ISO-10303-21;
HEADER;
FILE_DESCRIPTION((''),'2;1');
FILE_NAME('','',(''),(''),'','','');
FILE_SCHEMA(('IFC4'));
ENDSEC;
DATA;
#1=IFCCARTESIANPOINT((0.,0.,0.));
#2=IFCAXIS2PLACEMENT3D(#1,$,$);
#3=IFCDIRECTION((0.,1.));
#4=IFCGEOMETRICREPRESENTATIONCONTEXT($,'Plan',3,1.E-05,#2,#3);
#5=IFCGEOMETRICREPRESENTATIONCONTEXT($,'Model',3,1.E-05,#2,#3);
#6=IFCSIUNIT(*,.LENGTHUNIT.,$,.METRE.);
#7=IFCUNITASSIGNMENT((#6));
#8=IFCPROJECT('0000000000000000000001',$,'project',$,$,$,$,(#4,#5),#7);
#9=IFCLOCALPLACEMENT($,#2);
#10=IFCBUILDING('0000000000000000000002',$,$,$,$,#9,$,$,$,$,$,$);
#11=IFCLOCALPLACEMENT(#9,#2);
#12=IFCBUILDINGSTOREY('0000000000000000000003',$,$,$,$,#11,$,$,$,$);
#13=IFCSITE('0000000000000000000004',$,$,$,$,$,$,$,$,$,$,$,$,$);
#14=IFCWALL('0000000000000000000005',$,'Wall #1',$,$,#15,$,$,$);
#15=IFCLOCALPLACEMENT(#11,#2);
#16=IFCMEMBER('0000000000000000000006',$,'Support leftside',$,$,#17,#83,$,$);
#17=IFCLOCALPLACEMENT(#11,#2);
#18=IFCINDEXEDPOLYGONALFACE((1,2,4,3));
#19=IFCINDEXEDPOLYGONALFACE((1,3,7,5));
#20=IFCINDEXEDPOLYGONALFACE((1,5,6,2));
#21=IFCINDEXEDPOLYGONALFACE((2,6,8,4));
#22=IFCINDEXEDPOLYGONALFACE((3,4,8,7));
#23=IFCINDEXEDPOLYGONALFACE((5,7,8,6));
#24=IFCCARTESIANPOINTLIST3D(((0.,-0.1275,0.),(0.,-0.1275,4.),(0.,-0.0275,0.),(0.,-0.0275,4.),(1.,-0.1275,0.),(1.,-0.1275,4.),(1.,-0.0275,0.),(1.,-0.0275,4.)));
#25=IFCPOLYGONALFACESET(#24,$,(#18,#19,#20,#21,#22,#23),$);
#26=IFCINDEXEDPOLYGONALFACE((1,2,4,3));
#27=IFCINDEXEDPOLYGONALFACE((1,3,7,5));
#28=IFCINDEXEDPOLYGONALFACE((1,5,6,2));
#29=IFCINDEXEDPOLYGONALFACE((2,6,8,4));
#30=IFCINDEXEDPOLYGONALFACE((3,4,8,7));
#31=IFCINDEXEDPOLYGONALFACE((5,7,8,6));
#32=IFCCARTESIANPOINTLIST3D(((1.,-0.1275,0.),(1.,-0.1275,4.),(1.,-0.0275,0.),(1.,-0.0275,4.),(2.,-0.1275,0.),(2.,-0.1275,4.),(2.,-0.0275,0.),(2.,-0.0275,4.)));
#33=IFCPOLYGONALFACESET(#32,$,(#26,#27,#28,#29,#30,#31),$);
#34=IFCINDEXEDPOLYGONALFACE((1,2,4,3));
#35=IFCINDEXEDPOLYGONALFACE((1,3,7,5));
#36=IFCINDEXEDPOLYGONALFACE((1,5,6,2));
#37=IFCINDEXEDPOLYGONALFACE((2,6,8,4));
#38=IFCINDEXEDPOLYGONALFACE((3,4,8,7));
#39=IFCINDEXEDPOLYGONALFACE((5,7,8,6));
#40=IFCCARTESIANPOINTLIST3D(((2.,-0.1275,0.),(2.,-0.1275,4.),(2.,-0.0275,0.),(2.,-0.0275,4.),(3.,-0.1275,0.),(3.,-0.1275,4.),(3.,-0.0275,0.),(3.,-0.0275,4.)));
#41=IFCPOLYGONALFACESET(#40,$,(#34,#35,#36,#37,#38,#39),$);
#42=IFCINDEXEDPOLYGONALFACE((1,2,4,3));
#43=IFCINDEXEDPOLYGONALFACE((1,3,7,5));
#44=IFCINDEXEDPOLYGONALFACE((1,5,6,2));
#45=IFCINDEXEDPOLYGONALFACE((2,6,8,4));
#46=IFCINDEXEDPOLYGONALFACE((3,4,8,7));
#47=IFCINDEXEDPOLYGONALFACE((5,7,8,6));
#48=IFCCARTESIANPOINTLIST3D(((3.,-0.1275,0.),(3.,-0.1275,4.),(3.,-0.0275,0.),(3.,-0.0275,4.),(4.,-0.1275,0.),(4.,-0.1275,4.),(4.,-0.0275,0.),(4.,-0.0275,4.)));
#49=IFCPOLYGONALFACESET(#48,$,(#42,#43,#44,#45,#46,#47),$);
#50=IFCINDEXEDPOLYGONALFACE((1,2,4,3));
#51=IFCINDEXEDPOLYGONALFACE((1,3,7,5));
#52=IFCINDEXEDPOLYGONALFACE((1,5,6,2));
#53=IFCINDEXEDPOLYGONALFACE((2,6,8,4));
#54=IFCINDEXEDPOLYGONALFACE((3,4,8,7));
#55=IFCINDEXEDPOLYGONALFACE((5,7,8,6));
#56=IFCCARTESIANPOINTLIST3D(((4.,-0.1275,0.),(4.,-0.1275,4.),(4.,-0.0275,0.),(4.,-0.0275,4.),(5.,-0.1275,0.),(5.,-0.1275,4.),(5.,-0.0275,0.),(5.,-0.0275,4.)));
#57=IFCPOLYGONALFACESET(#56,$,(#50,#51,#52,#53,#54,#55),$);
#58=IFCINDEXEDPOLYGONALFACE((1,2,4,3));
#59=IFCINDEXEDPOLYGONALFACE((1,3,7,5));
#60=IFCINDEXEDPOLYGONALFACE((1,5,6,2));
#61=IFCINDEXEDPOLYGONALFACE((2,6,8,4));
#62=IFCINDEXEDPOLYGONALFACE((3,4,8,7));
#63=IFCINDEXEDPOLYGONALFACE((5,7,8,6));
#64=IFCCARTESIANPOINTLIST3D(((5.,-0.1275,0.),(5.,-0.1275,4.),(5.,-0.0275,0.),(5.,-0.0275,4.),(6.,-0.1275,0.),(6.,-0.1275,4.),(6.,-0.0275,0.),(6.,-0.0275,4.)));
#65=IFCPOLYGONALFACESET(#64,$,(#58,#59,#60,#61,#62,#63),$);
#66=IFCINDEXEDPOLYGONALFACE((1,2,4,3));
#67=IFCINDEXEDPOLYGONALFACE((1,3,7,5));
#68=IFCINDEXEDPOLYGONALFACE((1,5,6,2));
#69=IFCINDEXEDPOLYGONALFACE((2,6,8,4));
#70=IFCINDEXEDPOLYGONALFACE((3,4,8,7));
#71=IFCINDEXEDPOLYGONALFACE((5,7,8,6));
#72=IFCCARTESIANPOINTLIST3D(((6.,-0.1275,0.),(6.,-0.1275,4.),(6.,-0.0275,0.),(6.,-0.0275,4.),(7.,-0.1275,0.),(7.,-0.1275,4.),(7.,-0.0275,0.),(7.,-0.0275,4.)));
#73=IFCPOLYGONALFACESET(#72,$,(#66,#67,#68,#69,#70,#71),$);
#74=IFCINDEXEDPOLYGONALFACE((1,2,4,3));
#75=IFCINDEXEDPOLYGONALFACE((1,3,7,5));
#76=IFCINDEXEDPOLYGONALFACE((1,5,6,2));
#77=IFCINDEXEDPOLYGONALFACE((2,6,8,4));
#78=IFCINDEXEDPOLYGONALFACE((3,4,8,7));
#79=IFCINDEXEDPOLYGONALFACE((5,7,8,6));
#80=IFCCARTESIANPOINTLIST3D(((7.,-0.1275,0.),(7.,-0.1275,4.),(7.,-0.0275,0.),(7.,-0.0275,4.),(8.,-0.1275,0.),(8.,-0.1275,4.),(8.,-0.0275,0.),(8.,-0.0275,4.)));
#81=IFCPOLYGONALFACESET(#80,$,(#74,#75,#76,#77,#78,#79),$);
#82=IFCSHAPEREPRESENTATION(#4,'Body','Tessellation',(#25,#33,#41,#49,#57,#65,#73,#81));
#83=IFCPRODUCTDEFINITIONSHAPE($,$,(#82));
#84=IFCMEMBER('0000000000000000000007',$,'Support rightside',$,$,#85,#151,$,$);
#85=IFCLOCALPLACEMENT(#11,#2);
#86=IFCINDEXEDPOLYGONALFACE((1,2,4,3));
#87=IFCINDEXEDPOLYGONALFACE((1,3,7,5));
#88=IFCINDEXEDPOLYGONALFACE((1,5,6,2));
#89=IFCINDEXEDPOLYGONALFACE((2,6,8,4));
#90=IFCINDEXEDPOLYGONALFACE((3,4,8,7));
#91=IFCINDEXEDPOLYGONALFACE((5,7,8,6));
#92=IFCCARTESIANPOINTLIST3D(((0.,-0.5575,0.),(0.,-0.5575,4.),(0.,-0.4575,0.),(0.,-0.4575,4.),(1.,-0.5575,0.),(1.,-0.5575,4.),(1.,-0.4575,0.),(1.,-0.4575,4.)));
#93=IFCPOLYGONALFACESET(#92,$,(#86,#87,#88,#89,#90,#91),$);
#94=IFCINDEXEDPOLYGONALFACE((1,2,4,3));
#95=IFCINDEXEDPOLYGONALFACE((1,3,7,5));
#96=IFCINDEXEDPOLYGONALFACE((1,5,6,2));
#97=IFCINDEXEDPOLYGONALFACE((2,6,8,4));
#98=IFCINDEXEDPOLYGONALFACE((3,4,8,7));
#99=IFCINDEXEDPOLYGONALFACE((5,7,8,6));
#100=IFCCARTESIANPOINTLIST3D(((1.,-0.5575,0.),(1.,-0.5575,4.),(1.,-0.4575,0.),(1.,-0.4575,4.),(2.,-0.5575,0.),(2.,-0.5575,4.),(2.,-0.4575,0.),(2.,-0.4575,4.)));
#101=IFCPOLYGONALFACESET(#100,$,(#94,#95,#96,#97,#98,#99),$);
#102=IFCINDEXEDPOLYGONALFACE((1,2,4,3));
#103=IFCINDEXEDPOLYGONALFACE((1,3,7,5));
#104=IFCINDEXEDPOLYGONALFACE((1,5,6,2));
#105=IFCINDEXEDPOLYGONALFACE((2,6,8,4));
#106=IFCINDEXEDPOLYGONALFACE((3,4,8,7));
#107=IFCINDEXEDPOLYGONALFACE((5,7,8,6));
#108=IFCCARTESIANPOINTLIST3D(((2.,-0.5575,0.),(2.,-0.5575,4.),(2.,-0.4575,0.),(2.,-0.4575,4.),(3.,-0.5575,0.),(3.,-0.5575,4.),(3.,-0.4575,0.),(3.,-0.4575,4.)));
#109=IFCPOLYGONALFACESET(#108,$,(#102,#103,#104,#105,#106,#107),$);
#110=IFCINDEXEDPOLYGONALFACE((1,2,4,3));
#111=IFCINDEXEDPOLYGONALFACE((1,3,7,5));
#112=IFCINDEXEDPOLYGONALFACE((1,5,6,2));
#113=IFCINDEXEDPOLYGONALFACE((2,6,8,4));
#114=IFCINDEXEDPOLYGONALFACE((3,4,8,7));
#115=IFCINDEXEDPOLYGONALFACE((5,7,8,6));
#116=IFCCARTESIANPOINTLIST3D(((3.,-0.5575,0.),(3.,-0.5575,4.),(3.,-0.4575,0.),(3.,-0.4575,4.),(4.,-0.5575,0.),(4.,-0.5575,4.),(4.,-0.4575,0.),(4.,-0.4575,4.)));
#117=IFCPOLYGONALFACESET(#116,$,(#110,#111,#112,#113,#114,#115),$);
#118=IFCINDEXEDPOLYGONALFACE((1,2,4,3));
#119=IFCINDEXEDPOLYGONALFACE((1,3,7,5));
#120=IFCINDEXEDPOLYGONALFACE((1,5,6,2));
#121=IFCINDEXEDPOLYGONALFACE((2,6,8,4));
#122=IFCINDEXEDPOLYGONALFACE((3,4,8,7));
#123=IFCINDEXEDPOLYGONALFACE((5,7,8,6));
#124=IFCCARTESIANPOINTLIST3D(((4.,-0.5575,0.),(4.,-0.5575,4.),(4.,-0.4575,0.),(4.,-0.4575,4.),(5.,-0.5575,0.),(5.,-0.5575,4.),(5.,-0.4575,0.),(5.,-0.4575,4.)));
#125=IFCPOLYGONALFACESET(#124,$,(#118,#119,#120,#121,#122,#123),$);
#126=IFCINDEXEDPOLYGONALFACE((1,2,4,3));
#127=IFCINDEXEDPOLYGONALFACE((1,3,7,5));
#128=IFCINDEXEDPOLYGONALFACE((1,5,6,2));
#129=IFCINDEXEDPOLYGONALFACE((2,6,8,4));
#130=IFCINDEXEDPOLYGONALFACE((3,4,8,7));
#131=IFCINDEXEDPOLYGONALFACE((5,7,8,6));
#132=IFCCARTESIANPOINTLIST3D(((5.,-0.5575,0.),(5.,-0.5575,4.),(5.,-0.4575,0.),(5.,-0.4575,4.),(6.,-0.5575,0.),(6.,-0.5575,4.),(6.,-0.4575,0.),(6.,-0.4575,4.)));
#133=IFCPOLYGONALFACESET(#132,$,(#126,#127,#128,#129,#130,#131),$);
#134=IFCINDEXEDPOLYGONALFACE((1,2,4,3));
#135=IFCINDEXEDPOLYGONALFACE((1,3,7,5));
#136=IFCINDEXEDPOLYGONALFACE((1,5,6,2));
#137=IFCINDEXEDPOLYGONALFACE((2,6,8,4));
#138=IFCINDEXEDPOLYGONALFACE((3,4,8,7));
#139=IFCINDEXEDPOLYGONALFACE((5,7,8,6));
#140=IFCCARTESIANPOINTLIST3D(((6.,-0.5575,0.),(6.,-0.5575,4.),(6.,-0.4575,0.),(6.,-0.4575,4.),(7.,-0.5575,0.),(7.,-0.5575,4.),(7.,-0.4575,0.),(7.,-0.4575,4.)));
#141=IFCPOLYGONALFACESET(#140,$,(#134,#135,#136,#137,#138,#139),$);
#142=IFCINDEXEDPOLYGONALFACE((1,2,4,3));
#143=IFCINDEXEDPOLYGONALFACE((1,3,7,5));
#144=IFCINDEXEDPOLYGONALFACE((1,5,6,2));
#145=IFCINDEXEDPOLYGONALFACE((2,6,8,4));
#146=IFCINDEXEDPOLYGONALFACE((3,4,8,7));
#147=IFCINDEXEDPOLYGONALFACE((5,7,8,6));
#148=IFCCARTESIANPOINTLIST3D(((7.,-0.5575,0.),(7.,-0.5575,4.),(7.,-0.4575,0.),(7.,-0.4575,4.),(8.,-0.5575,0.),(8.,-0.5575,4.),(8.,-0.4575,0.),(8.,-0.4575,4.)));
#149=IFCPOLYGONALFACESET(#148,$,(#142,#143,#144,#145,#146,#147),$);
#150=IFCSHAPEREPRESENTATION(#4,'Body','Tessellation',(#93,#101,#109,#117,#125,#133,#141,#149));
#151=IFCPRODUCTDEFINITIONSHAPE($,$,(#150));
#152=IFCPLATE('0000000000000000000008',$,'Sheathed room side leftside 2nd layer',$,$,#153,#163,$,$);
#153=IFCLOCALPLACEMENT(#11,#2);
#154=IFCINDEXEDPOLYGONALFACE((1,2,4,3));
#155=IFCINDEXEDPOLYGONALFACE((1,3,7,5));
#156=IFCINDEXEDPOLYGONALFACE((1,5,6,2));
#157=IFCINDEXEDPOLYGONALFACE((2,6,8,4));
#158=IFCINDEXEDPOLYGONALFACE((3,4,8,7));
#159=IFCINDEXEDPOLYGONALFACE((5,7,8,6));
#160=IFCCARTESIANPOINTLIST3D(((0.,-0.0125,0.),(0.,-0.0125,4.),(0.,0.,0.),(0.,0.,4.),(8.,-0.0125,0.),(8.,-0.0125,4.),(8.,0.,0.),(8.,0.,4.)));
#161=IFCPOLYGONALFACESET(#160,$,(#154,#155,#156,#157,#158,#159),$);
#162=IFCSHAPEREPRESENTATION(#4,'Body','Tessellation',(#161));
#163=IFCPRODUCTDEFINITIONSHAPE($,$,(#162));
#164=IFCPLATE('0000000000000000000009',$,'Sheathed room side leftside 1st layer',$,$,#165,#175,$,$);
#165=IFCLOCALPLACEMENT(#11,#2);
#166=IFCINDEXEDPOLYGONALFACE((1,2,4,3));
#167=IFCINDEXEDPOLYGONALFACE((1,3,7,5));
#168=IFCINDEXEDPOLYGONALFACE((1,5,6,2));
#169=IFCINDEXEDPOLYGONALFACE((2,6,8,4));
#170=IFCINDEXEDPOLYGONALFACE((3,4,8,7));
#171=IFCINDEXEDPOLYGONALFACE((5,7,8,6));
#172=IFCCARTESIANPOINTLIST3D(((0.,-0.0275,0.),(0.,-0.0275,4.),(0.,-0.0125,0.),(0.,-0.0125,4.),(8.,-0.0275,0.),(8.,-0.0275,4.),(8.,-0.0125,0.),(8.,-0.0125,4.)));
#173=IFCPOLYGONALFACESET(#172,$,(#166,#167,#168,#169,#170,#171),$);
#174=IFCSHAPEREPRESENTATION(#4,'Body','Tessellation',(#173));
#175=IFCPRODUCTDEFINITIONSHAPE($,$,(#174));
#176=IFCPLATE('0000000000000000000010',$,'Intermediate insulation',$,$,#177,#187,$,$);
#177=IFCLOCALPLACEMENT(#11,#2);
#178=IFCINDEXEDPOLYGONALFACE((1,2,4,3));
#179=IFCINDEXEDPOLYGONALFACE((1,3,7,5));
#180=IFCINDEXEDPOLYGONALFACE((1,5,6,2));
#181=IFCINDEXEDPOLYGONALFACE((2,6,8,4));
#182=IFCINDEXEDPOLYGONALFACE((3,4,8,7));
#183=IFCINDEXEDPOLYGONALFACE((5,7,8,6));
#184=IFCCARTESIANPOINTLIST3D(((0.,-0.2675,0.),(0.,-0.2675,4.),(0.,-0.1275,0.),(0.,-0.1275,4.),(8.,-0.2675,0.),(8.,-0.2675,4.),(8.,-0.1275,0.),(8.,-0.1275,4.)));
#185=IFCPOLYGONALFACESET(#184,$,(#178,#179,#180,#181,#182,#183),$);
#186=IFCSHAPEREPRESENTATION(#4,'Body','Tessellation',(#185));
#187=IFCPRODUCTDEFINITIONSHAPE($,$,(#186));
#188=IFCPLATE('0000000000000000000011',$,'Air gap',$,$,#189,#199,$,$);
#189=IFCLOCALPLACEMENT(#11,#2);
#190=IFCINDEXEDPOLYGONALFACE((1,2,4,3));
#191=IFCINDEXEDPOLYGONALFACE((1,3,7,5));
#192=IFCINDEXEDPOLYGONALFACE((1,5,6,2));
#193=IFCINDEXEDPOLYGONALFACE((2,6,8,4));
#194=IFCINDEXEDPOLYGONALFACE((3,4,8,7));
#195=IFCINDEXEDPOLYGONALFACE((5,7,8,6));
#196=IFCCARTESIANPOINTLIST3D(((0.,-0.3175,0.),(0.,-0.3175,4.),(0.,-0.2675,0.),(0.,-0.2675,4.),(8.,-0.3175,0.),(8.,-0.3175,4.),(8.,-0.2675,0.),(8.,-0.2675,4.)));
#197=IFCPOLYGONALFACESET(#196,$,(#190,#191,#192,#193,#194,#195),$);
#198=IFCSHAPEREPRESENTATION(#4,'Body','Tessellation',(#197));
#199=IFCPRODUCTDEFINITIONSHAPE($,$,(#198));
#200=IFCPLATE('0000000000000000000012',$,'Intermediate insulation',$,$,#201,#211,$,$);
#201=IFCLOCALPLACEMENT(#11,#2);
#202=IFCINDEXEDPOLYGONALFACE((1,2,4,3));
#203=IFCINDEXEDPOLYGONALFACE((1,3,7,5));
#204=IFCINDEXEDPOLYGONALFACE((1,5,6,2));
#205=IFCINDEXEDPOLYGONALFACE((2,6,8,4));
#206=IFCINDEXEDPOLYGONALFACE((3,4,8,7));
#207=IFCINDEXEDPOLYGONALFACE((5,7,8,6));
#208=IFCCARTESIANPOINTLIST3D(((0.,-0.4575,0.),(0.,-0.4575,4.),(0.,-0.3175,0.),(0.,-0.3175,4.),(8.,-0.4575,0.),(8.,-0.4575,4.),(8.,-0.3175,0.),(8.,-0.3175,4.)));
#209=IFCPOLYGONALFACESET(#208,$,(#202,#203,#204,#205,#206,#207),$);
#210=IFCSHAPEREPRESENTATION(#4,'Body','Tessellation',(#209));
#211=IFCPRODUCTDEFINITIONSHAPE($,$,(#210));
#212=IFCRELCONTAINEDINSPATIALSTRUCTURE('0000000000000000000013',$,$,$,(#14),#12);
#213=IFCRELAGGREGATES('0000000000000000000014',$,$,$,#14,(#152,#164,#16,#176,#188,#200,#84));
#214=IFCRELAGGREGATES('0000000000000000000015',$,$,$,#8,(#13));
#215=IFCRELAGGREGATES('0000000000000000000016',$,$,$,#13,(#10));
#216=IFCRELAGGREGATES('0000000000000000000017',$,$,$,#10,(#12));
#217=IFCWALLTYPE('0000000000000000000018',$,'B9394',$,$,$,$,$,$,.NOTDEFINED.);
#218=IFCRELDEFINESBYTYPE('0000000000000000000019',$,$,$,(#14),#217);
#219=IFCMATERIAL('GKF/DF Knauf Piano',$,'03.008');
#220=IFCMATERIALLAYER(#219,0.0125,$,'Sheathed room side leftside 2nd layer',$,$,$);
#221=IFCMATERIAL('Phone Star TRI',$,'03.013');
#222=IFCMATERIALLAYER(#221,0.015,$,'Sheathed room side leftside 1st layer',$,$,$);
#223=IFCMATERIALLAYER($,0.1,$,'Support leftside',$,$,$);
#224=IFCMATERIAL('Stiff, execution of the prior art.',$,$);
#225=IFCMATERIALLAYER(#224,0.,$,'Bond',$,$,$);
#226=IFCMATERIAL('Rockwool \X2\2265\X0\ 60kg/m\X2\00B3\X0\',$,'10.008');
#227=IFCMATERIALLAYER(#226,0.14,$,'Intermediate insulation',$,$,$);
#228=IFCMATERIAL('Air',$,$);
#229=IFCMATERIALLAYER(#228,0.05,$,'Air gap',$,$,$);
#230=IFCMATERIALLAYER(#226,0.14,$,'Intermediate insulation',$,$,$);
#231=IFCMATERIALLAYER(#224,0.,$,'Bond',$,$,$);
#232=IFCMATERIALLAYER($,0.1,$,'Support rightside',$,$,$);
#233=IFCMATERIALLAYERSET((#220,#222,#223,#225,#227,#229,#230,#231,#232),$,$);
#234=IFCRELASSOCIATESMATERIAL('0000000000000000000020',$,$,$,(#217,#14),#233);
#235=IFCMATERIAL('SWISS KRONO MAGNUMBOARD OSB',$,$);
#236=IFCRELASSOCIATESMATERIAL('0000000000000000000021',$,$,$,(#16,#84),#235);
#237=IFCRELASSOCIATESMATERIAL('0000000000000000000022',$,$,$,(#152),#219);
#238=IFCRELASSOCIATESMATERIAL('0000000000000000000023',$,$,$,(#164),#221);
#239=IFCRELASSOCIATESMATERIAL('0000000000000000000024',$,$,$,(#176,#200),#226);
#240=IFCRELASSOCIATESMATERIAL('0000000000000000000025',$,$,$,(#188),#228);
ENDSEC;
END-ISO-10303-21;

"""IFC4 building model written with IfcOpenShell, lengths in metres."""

from ifc_helpers import new_model, si_unit, direction, frame, frame_2d, origin, origin_with_axes, place, context, project, spatial, rectangle, extrude, material, layer, layer_set, type_object, element, aggregate, save


model = new_model("IFC4")

# Units and contexts
plan_context = context("Plan", 3, precision=1e-05, world=origin(), true_north=direction((0.0, 1.0)))
model_context = context("Model", 3, precision=1e-05, world=origin(), true_north=direction((0.0, 1.0)))
ifc_project = project(units=[si_unit("LENGTHUNIT", "METRE")], contexts=[plan_context, model_context])

# Site, building, storey
site = spatial("IfcSite", under=ifc_project)
building_placement = place(None, origin())
building = spatial("IfcBuilding", under=site, at=building_placement)
storey_placement = place(building_placement, origin())
storey = spatial("IfcBuildingStorey", under=building, at=storey_placement)

# Wall, members, plates
ifc_material_1 = material(Name="GKF/DF Knauf Piano", Category="03.008")
ifc_layer_1 = layer(ifc_material_1, 0.0125, Name="Sheathed room side leftside 2nd layer")
ifc_material_2 = material(Name="Phone Star TRI", Category="03.013")
ifc_layer_2 = layer(ifc_material_2, 0.015, Name="Sheathed room side leftside 1st layer")
ifc_layer_3 = layer(None, 0.1, Name="Support leftside")
ifc_material_3 = material(Name="Stiff, execution of the prior art.")
ifc_layer_4 = layer(ifc_material_3, 0.0, Name="Bond")
ifc_material_4 = material(Name="Rockwool ≥ 60kg/m³", Category="10.008")
ifc_layer_5 = layer(ifc_material_4, 0.14, Name="Intermediate insulation")
ifc_material_5 = material(Name="Air")
ifc_layer_6 = layer(ifc_material_5, 0.05, Name="Air gap")
ifc_layer_7 = layer(ifc_material_4, 0.14, Name="Intermediate insulation")
ifc_layer_8 = layer(ifc_material_3, 0.0, Name="Bond")
ifc_layer_9 = layer(None, 0.1, Name="Support rightside")
ifc_layer_set = layer_set([ifc_layer_1, ifc_layer_2, ifc_layer_3, ifc_layer_4, ifc_layer_5, ifc_layer_6, ifc_layer_7, ifc_layer_8, ifc_layer_9])
wall_type = type_object("IfcWallType", Name="B9394", PredefinedType="NOTDEFINED", material=ifc_layer_set)
wall_placement = place(None, frame((0.0, 0.0, 0.0), z_axis=(0.0, -1.0, 0.0), x_axis=(1.0, 0.0, 0.0)))
wall = element("IfcWall", 1, at=wall_placement, inside=storey, type_object=wall_type, material=ifc_layer_set, Name="Wall #1")
ifc_material_6 = material(Name="SWISS KRONO MAGNUMBOARD OSB")
member_1_placement = place(wall_placement, origin())
member_1 = element("IfcMember", 2, at=member_1_placement, material=ifc_material_6, Name="Support leftside", context=plan_context, shape_type="SweptSolid", body=[
    extrude(rectangle(XDim=1.0, YDim=0.1, at=frame_2d((0.5, 0.05), x_axis=(1.0, 0.0))), frame((0.0, 4.0, 0.0275), z_axis=(0.0, -1.0, 0.0), x_axis=(1.0, 0.0, 0.0)), (0.0, 0.0, 1.0), 4.0),
    extrude(rectangle(XDim=1.0, YDim=0.1, at=frame_2d((0.5, 0.05), x_axis=(1.0, 0.0))), frame((1.0, 4.0, 0.0275), z_axis=(0.0, -1.0, 0.0), x_axis=(1.0, 0.0, 0.0)), (0.0, 0.0, 1.0), 4.0),
    extrude(rectangle(XDim=1.0, YDim=0.1, at=frame_2d((0.5, 0.05), x_axis=(1.0, 0.0))), frame((2.0, 4.0, 0.0275), z_axis=(0.0, -1.0, 0.0), x_axis=(1.0, 0.0, 0.0)), (0.0, 0.0, 1.0), 4.0),
    extrude(rectangle(XDim=1.0, YDim=0.1, at=frame_2d((0.5, 0.05), x_axis=(1.0, 0.0))), frame((3.0, 4.0, 0.0275), z_axis=(0.0, -1.0, 0.0), x_axis=(1.0, 0.0, 0.0)), (0.0, 0.0, 1.0), 4.0),
    extrude(rectangle(XDim=1.0, YDim=0.1, at=frame_2d((0.5, 0.05), x_axis=(1.0, 0.0))), frame((4.0, 4.0, 0.0275), z_axis=(0.0, -1.0, 0.0), x_axis=(1.0, 0.0, 0.0)), (0.0, 0.0, 1.0), 4.0),
    extrude(rectangle(XDim=1.0, YDim=0.1, at=frame_2d((0.5, 0.05), x_axis=(1.0, 0.0))), frame((5.0, 4.0, 0.0275), z_axis=(0.0, -1.0, 0.0), x_axis=(1.0, 0.0, 0.0)), (0.0, 0.0, 1.0), 4.0),
    extrude(rectangle(XDim=1.0, YDim=0.1, at=frame_2d((0.5, 0.05), x_axis=(1.0, 0.0))), frame((6.0, 4.0, 0.0275), z_axis=(0.0, -1.0, 0.0), x_axis=(1.0, 0.0, 0.0)), (0.0, 0.0, 1.0), 4.0),
    extrude(rectangle(XDim=1.0, YDim=0.1, at=frame_2d((0.5, 0.05), x_axis=(1.0, 0.0))), frame((7.0, 4.0, 0.0275), z_axis=(0.0, -1.0, 0.0), x_axis=(1.0, 0.0, 0.0)), (0.0, 0.0, 1.0), 4.0),
])
member_2_placement = place(wall_placement, origin())
member_2 = element("IfcMember", 3, at=member_2_placement, material=ifc_material_6, Name="Support rightside", context=plan_context, shape_type="SweptSolid", body=[
    extrude(rectangle(XDim=1.0, YDim=0.1, at=frame_2d((0.5, 0.05), x_axis=(1.0, 0.0))), frame((0.0, 4.0, 0.4575), z_axis=(0.0, -1.0, 0.0), x_axis=(1.0, 0.0, 0.0)), (0.0, 0.0, 1.0), 4.0),
    extrude(rectangle(XDim=1.0, YDim=0.1, at=frame_2d((0.5, 0.05), x_axis=(1.0, 0.0))), frame((1.0, 4.0, 0.4575), z_axis=(0.0, -1.0, 0.0), x_axis=(1.0, 0.0, 0.0)), (0.0, 0.0, 1.0), 4.0),
    extrude(rectangle(XDim=1.0, YDim=0.1, at=frame_2d((0.5, 0.05), x_axis=(1.0, 0.0))), frame((2.0, 4.0, 0.4575), z_axis=(0.0, -1.0, 0.0), x_axis=(1.0, 0.0, 0.0)), (0.0, 0.0, 1.0), 4.0),
    extrude(rectangle(XDim=1.0, YDim=0.1, at=frame_2d((0.5, 0.05), x_axis=(1.0, 0.0))), frame((3.0, 4.0, 0.4575), z_axis=(0.0, -1.0, 0.0), x_axis=(1.0, 0.0, 0.0)), (0.0, 0.0, 1.0), 4.0),
    extrude(rectangle(XDim=1.0, YDim=0.1, at=frame_2d((0.5, 0.05), x_axis=(1.0, 0.0))), frame((4.0, 4.0, 0.4575), z_axis=(0.0, -1.0, 0.0), x_axis=(1.0, 0.0, 0.0)), (0.0, 0.0, 1.0), 4.0),
    extrude(rectangle(XDim=1.0, YDim=0.1, at=frame_2d((0.5, 0.05), x_axis=(1.0, 0.0))), frame((5.0, 4.0, 0.4575), z_axis=(0.0, -1.0, 0.0), x_axis=(1.0, 0.0, 0.0)), (0.0, 0.0, 1.0), 4.0),
    extrude(rectangle(XDim=1.0, YDim=0.1, at=frame_2d((0.5, 0.05), x_axis=(1.0, 0.0))), frame((6.0, 4.0, 0.4575), z_axis=(0.0, -1.0, 0.0), x_axis=(1.0, 0.0, 0.0)), (0.0, 0.0, 1.0), 4.0),
    extrude(rectangle(XDim=1.0, YDim=0.1, at=frame_2d((0.5, 0.05), x_axis=(1.0, 0.0))), frame((7.0, 4.0, 0.4575), z_axis=(0.0, -1.0, 0.0), x_axis=(1.0, 0.0, 0.0)), (0.0, 0.0, 1.0), 4.0),
])
plate_1_placement = place(wall_placement, origin())
plate_1 = element("IfcPlate", 4, at=plate_1_placement, material=ifc_material_1, Name="Sheathed room side leftside 2nd layer", context=plan_context, shape_type="SweptSolid", body=[
    extrude(rectangle(XDim=8.0, YDim=4.0, at=frame_2d((4.0, 2.0), x_axis=(1.0, 0.0))), origin_with_axes(), (0.0, 0.0, 1.0), 0.0125),
])
plate_2_placement = place(wall_placement, origin())
plate_2 = element("IfcPlate", 5, at=plate_2_placement, material=ifc_material_2, Name="Sheathed room side leftside 1st layer", context=plan_context, shape_type="SweptSolid", body=[
    extrude(rectangle(XDim=8.0, YDim=4.0, at=frame_2d((4.0, 2.0), x_axis=(1.0, 0.0))), frame((0.0, 0.0, 0.0125), z_axis=(0.0, 0.0, 1.0), x_axis=(1.0, 0.0, 0.0)), (0.0, 0.0, 1.0), 0.015),
])
plate_3_placement = place(wall_placement, origin())
plate_3 = element("IfcPlate", 6, at=plate_3_placement, material=ifc_material_4, Name="Intermediate insulation", context=plan_context, shape_type="SweptSolid", body=[
    extrude(rectangle(XDim=8.0, YDim=4.0, at=frame_2d((4.0, 2.0), x_axis=(1.0, 0.0))), frame((0.0, 0.0, 0.1275), z_axis=(0.0, 0.0, 1.0), x_axis=(1.0, 0.0, 0.0)), (0.0, 0.0, 1.0), 0.14),
])
plate_4_placement = place(wall_placement, origin())
plate_4 = element("IfcPlate", 7, at=plate_4_placement, material=ifc_material_5, Name="Air gap", context=plan_context, shape_type="SweptSolid", body=[
    extrude(rectangle(XDim=8.0, YDim=4.0, at=frame_2d((4.0, 2.0), x_axis=(1.0, 0.0))), frame((0.0, 0.0, 0.2675), z_axis=(0.0, 0.0, 1.0), x_axis=(1.0, 0.0, 0.0)), (0.0, 0.0, 1.0), 0.05),
])
plate_5_placement = place(wall_placement, origin())
plate_5 = element("IfcPlate", 8, at=plate_5_placement, material=ifc_material_4, Name="Intermediate insulation", context=plan_context, shape_type="SweptSolid", body=[
    extrude(rectangle(XDim=8.0, YDim=4.0, at=frame_2d((4.0, 2.0), x_axis=(1.0, 0.0))), frame((0.0, 0.0, 0.3175), z_axis=(0.0, 0.0, 1.0), x_axis=(1.0, 0.0, 0.0)), (0.0, 0.0, 1.0), 0.14),
])
aggregate(wall, [plate_1, plate_2, member_1, plate_3, plate_4, plate_5, member_2])

save(model, "model.ifc")
